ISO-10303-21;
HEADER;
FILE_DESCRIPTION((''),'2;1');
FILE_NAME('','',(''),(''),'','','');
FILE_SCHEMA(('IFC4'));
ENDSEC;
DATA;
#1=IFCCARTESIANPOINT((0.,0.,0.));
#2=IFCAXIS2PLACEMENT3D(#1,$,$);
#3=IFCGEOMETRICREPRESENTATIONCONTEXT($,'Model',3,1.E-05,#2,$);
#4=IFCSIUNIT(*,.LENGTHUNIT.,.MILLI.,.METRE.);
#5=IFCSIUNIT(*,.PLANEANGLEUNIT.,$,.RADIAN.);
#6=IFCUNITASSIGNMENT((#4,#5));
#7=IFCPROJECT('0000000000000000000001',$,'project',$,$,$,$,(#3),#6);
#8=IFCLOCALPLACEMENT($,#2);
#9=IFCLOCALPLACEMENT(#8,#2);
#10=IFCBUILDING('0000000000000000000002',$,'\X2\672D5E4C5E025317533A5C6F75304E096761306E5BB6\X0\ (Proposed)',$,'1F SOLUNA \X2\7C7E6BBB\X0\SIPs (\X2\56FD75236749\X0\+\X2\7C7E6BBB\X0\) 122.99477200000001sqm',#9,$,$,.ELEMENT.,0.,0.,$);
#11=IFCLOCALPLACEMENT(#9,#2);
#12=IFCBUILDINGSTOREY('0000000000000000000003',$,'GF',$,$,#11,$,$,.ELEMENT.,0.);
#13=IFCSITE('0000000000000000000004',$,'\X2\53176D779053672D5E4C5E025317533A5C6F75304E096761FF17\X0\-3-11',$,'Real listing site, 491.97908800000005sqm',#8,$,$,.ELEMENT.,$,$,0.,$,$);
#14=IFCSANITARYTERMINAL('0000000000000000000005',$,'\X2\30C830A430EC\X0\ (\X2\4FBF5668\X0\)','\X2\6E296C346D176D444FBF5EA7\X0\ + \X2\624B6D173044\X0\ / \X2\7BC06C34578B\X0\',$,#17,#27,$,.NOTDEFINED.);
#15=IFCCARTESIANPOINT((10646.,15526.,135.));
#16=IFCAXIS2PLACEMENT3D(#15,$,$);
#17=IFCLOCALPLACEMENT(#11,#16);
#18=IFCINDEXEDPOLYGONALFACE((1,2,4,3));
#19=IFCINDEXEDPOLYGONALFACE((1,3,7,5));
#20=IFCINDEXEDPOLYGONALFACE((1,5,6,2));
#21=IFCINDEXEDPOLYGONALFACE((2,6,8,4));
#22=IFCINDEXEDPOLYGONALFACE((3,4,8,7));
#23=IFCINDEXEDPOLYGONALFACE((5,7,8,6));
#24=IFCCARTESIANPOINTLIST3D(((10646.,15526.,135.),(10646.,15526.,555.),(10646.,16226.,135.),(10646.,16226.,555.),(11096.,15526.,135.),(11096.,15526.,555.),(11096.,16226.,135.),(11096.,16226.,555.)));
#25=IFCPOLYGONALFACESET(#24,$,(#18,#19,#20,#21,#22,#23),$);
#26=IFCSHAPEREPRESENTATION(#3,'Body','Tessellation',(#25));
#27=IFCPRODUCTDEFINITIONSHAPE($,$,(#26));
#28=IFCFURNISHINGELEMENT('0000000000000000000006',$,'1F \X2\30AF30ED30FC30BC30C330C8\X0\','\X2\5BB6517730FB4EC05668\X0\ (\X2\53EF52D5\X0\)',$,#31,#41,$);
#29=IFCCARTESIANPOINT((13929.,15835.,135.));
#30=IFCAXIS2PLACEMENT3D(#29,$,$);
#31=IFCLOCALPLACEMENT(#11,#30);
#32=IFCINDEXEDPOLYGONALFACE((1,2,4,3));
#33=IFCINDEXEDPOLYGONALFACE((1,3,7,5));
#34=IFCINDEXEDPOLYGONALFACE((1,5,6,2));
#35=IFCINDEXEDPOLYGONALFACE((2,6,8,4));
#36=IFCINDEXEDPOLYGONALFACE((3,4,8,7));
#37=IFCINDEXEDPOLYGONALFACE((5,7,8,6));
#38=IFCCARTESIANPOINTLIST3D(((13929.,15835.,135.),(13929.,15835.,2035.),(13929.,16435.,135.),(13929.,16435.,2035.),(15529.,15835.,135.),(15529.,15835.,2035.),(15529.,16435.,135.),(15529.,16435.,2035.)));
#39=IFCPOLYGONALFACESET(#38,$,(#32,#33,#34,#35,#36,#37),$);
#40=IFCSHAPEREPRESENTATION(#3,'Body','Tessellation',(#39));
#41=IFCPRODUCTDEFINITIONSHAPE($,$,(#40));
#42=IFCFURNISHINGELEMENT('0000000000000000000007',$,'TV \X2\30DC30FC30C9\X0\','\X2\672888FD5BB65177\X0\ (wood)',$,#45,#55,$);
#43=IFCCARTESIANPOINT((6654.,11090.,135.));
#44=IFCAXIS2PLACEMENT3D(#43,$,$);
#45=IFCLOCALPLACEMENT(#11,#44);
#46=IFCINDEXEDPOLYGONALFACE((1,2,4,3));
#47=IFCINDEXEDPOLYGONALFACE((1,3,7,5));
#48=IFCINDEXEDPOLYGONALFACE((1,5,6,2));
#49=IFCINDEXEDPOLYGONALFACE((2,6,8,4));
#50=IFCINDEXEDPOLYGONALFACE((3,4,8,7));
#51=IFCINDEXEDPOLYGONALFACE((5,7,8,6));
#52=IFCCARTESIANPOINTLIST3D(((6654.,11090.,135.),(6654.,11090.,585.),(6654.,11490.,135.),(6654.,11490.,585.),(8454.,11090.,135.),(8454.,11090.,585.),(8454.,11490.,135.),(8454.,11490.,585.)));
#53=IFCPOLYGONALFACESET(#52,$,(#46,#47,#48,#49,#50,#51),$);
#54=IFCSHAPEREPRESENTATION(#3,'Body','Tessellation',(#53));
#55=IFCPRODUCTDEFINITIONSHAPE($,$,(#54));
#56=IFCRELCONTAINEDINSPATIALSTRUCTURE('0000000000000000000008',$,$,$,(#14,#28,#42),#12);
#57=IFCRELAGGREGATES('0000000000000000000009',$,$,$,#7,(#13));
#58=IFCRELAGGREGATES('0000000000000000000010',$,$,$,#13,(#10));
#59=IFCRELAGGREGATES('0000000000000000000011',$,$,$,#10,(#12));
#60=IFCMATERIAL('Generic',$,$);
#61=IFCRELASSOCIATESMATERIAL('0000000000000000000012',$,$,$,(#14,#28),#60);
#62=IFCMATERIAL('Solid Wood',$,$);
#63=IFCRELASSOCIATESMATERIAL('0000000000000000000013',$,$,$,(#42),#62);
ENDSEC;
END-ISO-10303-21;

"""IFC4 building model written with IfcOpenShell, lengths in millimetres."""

from ifc_helpers import new_model, si_unit, frame, frame_2d, origin, place, context, project, spatial, rectangle, extrude, material, element, save


model = new_model("IFC4")

# Units and contexts
model_context = context("Model", 3, precision=1e-05, world=origin())
ifc_project = project(units=[si_unit("LENGTHUNIT", "METRE", prefix="MILLI"), si_unit("PLANEANGLEUNIT", "RADIAN")], contexts=[model_context])

# Site, building, storey
site_placement = place(None, origin())
site = spatial("IfcSite", under=ifc_project, at=site_placement, Name="北海道札幌市北区屯田三条７-3-11", ObjectType="Real listing site, 491.97908800000005sqm", CompositionType="ELEMENT", RefElevation=0.0)
building_placement = place(site_placement, origin())
building = spatial("IfcBuilding", under=site, at=building_placement, Name="札幌市北区屯田三条の家 (Proposed)", ObjectType="1F SOLUNA 籾殻SIPs (国産杉+籾殻) 122.99477200000001sqm", CompositionType="ELEMENT", ElevationOfRefHeight=0.0, ElevationOfTerrain=0.0)
storey_placement = place(building_placement, origin())
storey = spatial("IfcBuildingStorey", under=building, at=storey_placement, Name="GF", CompositionType="ELEMENT", Elevation=0.0)

# Shared definitions
ifc_material_1 = material(Name="Solid Wood")

# Sanitary terminal
ifc_material_2 = material(Name="Generic")
sanitary_terminal_1_placement = place(storey_placement, frame((10646.0, 15526.0, 135.0)))
element("IfcSanitaryTerminal", 1, at=sanitary_terminal_1_placement, inside=storey, material=ifc_material_2, Name="トイレ (便器)", Description="温水洗浄便座 + 手洗い / 節水型", PredefinedType="NOTDEFINED", context=model_context, shape_type="SweptSolid", body=[
    extrude(rectangle(XDim=450.0, YDim=700.0, at=frame_2d((225.0, 350.0))), frame((10646.0, 15526.0, 135.0)), (0.0, 0.0, 1.0), 420.0),
])

# Furnishing elements
furnishing_1_placement = place(storey_placement, frame((13929.0, 15835.0, 135.0)))
element("IfcFurnishingElement", 2, at=furnishing_1_placement, inside=storey, material=ifc_material_2, Name="1F クローゼット", Description="家具・什器 (可動)", context=model_context, shape_type="SweptSolid", body=[
    extrude(rectangle(XDim=1600.0, YDim=600.0, at=frame_2d((800.0, 300.0))), frame((13929.0, 15835.0, 135.0)), (0.0, 0.0, 1.0), 1900.0),
])
furnishing_2_placement = place(storey_placement, frame((6654.0, 11090.0, 135.0)))
element("IfcFurnishingElement", 3, at=furnishing_2_placement, inside=storey, material=ifc_material_1, Name="TV ボード", Description="木製家具 (wood)", context=model_context, shape_type="SweptSolid", body=[
    extrude(rectangle(XDim=1800.0, YDim=400.0, at=frame_2d((900.0, 200.0))), frame((6654.0, 11090.0, 135.0)), (0.0, 0.0, 1.0), 450.0),
])

save(model, "model.ifc")
